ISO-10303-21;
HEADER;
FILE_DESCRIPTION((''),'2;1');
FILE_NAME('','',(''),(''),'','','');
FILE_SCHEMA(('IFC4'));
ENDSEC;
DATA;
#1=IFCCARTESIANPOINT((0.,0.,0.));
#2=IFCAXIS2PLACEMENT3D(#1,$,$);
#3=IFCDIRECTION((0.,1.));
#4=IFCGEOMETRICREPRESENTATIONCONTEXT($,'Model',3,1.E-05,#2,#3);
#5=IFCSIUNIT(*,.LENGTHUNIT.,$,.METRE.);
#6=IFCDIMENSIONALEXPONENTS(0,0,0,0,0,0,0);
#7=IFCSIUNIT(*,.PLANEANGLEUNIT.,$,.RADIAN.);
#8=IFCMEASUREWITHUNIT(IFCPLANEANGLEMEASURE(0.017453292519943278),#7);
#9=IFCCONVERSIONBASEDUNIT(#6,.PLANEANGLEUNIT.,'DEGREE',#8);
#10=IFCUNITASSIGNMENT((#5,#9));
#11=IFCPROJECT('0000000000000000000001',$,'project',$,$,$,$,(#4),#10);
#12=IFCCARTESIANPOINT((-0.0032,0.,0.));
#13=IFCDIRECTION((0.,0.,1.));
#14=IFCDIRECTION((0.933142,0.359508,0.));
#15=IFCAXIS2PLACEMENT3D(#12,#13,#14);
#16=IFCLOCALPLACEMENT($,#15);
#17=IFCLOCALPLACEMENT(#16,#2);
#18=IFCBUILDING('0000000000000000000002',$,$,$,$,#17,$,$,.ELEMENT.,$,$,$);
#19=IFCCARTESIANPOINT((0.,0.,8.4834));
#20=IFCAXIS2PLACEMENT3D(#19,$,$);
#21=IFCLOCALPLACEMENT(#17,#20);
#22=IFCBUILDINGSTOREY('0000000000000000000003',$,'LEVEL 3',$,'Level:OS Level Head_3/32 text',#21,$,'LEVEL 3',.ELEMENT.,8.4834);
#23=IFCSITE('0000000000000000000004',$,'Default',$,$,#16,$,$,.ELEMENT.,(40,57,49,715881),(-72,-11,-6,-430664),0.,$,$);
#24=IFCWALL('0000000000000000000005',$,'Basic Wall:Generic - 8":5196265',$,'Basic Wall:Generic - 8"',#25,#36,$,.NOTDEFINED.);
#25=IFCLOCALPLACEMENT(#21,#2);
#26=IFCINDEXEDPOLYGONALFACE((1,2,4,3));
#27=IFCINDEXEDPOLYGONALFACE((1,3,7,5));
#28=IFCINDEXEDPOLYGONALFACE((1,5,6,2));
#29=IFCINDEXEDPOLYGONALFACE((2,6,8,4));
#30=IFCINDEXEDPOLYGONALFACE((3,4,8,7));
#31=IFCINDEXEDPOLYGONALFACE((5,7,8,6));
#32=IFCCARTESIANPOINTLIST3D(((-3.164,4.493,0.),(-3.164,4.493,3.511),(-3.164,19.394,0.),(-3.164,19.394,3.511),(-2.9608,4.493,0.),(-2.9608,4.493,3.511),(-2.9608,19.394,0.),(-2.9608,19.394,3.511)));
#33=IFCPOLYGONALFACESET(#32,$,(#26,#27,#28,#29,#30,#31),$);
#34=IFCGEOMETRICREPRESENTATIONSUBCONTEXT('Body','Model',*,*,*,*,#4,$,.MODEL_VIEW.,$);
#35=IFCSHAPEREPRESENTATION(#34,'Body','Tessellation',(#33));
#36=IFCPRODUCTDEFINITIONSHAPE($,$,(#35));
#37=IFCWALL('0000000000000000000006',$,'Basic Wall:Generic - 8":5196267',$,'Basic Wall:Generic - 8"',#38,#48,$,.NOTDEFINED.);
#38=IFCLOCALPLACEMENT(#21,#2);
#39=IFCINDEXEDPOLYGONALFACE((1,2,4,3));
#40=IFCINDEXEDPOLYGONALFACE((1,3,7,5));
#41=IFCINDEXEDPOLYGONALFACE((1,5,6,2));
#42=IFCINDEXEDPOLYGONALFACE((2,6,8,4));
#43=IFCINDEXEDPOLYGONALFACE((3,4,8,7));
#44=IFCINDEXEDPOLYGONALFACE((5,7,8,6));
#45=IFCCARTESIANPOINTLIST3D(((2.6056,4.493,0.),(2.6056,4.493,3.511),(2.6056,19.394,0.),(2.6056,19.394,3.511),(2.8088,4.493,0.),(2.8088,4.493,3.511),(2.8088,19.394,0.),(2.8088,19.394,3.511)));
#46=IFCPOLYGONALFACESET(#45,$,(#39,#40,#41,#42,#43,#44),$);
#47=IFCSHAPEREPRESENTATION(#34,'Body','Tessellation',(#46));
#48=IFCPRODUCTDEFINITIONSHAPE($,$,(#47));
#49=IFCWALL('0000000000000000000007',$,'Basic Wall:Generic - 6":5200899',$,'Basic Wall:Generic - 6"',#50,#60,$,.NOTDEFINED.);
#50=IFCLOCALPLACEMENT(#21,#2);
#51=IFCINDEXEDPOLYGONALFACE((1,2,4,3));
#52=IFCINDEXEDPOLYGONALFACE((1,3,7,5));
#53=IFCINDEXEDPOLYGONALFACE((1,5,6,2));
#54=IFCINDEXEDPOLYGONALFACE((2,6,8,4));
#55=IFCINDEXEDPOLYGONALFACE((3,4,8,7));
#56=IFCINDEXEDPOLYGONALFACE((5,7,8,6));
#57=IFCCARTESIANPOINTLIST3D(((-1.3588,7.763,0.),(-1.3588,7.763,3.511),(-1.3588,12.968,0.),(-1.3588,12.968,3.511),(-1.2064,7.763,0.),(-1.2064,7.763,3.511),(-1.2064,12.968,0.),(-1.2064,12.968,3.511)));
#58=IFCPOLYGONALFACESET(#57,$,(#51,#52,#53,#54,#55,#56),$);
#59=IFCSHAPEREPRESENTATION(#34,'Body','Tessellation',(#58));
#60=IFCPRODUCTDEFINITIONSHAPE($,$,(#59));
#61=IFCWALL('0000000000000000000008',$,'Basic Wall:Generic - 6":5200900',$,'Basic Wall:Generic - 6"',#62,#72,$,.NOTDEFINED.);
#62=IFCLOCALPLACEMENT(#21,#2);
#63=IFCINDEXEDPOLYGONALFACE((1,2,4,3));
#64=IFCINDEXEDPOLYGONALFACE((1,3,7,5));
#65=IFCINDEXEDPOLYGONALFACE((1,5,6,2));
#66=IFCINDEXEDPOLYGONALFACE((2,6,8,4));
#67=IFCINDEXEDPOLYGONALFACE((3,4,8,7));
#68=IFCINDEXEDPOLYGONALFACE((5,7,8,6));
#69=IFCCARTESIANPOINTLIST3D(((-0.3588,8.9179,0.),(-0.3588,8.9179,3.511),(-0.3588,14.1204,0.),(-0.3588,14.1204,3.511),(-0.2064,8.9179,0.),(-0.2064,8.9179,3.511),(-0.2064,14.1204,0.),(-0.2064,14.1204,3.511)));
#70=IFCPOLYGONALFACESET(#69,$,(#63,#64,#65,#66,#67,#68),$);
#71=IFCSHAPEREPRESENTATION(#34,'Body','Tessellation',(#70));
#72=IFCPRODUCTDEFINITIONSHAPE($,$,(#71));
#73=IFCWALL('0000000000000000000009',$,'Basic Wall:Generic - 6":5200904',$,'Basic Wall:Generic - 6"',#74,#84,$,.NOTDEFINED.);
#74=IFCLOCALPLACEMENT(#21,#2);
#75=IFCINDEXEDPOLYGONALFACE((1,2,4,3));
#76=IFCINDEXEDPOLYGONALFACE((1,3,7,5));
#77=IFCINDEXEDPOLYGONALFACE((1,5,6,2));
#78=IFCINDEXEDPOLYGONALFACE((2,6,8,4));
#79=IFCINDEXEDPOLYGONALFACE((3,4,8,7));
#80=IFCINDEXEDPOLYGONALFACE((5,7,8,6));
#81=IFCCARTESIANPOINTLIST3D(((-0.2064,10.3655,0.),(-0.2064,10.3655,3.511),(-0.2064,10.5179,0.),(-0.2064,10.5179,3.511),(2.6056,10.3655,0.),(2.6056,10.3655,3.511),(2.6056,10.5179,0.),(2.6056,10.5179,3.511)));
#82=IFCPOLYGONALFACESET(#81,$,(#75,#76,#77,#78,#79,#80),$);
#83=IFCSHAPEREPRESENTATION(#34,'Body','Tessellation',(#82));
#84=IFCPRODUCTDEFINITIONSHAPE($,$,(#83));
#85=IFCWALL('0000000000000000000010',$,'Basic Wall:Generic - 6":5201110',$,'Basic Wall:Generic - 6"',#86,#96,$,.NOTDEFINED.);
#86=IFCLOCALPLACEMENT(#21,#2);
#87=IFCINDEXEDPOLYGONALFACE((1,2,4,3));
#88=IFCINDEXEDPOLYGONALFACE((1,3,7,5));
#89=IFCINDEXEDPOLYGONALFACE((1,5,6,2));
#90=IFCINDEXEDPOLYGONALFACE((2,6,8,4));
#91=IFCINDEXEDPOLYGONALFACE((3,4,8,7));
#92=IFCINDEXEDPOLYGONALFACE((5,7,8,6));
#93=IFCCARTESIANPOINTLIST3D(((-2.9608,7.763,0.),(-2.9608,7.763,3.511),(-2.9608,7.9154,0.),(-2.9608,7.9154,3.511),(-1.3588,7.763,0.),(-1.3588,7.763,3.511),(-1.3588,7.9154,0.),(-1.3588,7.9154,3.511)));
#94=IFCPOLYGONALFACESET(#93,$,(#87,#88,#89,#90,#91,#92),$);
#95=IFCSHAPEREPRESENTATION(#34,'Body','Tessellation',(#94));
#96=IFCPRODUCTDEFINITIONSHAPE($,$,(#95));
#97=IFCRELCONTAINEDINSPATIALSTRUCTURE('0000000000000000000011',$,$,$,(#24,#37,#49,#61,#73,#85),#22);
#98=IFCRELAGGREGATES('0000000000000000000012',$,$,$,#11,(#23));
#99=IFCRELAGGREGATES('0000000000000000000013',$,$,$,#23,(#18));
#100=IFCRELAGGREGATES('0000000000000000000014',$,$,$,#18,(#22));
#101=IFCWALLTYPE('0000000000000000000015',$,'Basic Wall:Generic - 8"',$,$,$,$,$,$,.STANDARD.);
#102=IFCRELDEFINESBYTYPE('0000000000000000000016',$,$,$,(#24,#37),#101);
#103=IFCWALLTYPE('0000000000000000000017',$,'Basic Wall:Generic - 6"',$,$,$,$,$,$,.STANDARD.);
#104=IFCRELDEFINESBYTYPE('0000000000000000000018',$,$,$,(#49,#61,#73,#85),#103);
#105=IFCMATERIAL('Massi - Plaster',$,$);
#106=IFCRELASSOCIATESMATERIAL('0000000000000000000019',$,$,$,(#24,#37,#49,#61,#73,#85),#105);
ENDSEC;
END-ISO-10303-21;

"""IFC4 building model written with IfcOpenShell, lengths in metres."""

from ifc_helpers import new_model, entity, si_unit, converted_unit, direction, frame, origin, place, context, subcontext, project, spatial, indexed_curve, outline, extrude, material, type_object, element, save


model = new_model("IFC4")

# Units and contexts
model_context = context("Model", 3, precision=1e-05, world=origin(), true_north=direction((0.0, 1.0)))
body_context = subcontext(model_context, "Body", "Model", "MODEL_VIEW")
ifc_project = project(units=[si_unit("LENGTHUNIT", "METRE"), converted_unit("PLANEANGLEUNIT", "DEGREE", entity("IfcPlaneAngleMeasure", 0.017453292519943278), si_unit("PLANEANGLEUNIT", "RADIAN"), dimensions=[0, 0, 0, 0, 0, 0, 0])], contexts=[model_context])

# Site, building, storey
site_placement = place(None, frame((-0.0032, 0.0, 0.0), z_axis=(0.0, 0.0, 1.0), x_axis=(0.933142, 0.359508, 0.0)))
site = spatial("IfcSite", under=ifc_project, at=site_placement, Name="Default", CompositionType="ELEMENT", RefLatitude=(40, 57, 49, 715881), RefLongitude=(-72, -11, -6, -430664), RefElevation=0.0)
building_placement = place(site_placement, origin())
building = spatial("IfcBuilding", under=site, at=building_placement, CompositionType="ELEMENT")
storey_placement = place(building_placement, frame((0.0, 0.0, 8.4834)))
storey = spatial("IfcBuildingStorey", under=building, at=storey_placement, Name="LEVEL 3", ObjectType="Level:OS Level Head_3/32 text", LongName="LEVEL 3", CompositionType="ELEMENT", Elevation=8.4834)

# Walls
ifc_material_1 = material(Name="Massi - Plaster")
wall_type_1 = type_object("IfcWallType", Name="Basic Wall:Generic - 8\"", PredefinedType="STANDARD")
wall_1_placement = place(storey_placement, frame((-3.0624, 4.493, 0.0), z_axis=(0.0, 0.0, 1.0), x_axis=(0.0, 1.0, 0.0)))
element("IfcWall", 1, at=wall_1_placement, inside=storey, type_object=wall_type_1, material=ifc_material_1, Name="Basic Wall:Generic - 8\":5196265", ObjectType="Basic Wall:Generic - 8\"", PredefinedType="NOTDEFINED", context=body_context, shape_type="SweptSolid", body=[
    extrude(outline(indexed_curve([(14.901, 0.1016), (0.0, 0.1016), (0.0, -0.1016), (14.901, -0.1016), (14.901, 0.1016)], self_intersect=False)), origin(), (0.0, 0.0, 1.0), 3.511),
])
wall_2_placement = place(storey_placement, frame((2.7072, 19.394, 0.0), z_axis=(0.0, 0.0, 1.0), x_axis=(0.0, -1.0, 0.0)))
element("IfcWall", 2, at=wall_2_placement, inside=storey, type_object=wall_type_1, material=ifc_material_1, Name="Basic Wall:Generic - 8\":5196267", ObjectType="Basic Wall:Generic - 8\"", PredefinedType="NOTDEFINED", context=body_context, shape_type="SweptSolid", body=[
    extrude(outline(indexed_curve([(14.901, 0.1016), (0.0, 0.1016), (0.0, -0.1016), (14.901, -0.1016), (14.901, 0.1016)], self_intersect=False)), origin(), (0.0, 0.0, 1.0), 3.511),
])
wall_type_2 = type_object("IfcWallType", Name="Basic Wall:Generic - 6\"", PredefinedType="STANDARD")
wall_3_placement = place(storey_placement, frame((-1.2826, 12.968, 0.0), z_axis=(0.0, 0.0, 1.0), x_axis=(0.0, -1.0, 0.0)))
element("IfcWall", 3, at=wall_3_placement, inside=storey, type_object=wall_type_2, material=ifc_material_1, Name="Basic Wall:Generic - 6\":5200899", ObjectType="Basic Wall:Generic - 6\"", PredefinedType="NOTDEFINED", context=body_context, shape_type="SweptSolid", body=[
    extrude(outline(indexed_curve([(5.205, 0.0762), (0.0, 0.0762), (0.0, -0.0762), (5.205, -0.0762), (5.205, 0.0762)], self_intersect=False)), origin(), (0.0, 0.0, 1.0), 3.511),
])
wall_4_placement = place(storey_placement, frame((-0.2826, 14.1204, 0.0), z_axis=(0.0, 0.0, 1.0), x_axis=(0.0, -1.0, 0.0)))
element("IfcWall", 4, at=wall_4_placement, inside=storey, type_object=wall_type_2, material=ifc_material_1, Name="Basic Wall:Generic - 6\":5200900", ObjectType="Basic Wall:Generic - 6\"", PredefinedType="NOTDEFINED", context=body_context, shape_type="SweptSolid", body=[
    extrude(outline(indexed_curve([(5.2025, 0.0762), (0.0, 0.0762), (0.0, -0.0762), (5.2025, -0.0762), (5.2025, 0.0762)], self_intersect=False)), origin(), (0.0, 0.0, 1.0), 3.511),
])
wall_5_placement = place(storey_placement, frame((-0.2064, 10.4417, 0.0)))
element("IfcWall", 5, at=wall_5_placement, inside=storey, type_object=wall_type_2, material=ifc_material_1, Name="Basic Wall:Generic - 6\":5200904", ObjectType="Basic Wall:Generic - 6\"", PredefinedType="NOTDEFINED", context=body_context, shape_type="SweptSolid", body=[
    extrude(outline(indexed_curve([(2.812, 0.0762), (0.0, 0.0762), (0.0, -0.0762), (2.812, -0.0762), (2.812, 0.0762)], self_intersect=False)), origin(), (0.0, 0.0, 1.0), 3.511),
])
wall_6_placement = place(storey_placement, frame((-1.3588, 7.8392, 0.0), z_axis=(0.0, 0.0, 1.0), x_axis=(-1.0, 0.0, 0.0)))
element("IfcWall", 6, at=wall_6_placement, inside=storey, type_object=wall_type_2, material=ifc_material_1, Name="Basic Wall:Generic - 6\":5201110", ObjectType="Basic Wall:Generic - 6\"", PredefinedType="NOTDEFINED", context=body_context, shape_type="SweptSolid", body=[
    extrude(outline(indexed_curve([(1.602, 0.0762), (0.0, 0.0762), (0.0, -0.0762), (1.602, -0.0762), (1.602, 0.0762)], self_intersect=False)), origin(), (0.0, 0.0, 1.0), 3.511),
])

save(model, "model.ifc")
